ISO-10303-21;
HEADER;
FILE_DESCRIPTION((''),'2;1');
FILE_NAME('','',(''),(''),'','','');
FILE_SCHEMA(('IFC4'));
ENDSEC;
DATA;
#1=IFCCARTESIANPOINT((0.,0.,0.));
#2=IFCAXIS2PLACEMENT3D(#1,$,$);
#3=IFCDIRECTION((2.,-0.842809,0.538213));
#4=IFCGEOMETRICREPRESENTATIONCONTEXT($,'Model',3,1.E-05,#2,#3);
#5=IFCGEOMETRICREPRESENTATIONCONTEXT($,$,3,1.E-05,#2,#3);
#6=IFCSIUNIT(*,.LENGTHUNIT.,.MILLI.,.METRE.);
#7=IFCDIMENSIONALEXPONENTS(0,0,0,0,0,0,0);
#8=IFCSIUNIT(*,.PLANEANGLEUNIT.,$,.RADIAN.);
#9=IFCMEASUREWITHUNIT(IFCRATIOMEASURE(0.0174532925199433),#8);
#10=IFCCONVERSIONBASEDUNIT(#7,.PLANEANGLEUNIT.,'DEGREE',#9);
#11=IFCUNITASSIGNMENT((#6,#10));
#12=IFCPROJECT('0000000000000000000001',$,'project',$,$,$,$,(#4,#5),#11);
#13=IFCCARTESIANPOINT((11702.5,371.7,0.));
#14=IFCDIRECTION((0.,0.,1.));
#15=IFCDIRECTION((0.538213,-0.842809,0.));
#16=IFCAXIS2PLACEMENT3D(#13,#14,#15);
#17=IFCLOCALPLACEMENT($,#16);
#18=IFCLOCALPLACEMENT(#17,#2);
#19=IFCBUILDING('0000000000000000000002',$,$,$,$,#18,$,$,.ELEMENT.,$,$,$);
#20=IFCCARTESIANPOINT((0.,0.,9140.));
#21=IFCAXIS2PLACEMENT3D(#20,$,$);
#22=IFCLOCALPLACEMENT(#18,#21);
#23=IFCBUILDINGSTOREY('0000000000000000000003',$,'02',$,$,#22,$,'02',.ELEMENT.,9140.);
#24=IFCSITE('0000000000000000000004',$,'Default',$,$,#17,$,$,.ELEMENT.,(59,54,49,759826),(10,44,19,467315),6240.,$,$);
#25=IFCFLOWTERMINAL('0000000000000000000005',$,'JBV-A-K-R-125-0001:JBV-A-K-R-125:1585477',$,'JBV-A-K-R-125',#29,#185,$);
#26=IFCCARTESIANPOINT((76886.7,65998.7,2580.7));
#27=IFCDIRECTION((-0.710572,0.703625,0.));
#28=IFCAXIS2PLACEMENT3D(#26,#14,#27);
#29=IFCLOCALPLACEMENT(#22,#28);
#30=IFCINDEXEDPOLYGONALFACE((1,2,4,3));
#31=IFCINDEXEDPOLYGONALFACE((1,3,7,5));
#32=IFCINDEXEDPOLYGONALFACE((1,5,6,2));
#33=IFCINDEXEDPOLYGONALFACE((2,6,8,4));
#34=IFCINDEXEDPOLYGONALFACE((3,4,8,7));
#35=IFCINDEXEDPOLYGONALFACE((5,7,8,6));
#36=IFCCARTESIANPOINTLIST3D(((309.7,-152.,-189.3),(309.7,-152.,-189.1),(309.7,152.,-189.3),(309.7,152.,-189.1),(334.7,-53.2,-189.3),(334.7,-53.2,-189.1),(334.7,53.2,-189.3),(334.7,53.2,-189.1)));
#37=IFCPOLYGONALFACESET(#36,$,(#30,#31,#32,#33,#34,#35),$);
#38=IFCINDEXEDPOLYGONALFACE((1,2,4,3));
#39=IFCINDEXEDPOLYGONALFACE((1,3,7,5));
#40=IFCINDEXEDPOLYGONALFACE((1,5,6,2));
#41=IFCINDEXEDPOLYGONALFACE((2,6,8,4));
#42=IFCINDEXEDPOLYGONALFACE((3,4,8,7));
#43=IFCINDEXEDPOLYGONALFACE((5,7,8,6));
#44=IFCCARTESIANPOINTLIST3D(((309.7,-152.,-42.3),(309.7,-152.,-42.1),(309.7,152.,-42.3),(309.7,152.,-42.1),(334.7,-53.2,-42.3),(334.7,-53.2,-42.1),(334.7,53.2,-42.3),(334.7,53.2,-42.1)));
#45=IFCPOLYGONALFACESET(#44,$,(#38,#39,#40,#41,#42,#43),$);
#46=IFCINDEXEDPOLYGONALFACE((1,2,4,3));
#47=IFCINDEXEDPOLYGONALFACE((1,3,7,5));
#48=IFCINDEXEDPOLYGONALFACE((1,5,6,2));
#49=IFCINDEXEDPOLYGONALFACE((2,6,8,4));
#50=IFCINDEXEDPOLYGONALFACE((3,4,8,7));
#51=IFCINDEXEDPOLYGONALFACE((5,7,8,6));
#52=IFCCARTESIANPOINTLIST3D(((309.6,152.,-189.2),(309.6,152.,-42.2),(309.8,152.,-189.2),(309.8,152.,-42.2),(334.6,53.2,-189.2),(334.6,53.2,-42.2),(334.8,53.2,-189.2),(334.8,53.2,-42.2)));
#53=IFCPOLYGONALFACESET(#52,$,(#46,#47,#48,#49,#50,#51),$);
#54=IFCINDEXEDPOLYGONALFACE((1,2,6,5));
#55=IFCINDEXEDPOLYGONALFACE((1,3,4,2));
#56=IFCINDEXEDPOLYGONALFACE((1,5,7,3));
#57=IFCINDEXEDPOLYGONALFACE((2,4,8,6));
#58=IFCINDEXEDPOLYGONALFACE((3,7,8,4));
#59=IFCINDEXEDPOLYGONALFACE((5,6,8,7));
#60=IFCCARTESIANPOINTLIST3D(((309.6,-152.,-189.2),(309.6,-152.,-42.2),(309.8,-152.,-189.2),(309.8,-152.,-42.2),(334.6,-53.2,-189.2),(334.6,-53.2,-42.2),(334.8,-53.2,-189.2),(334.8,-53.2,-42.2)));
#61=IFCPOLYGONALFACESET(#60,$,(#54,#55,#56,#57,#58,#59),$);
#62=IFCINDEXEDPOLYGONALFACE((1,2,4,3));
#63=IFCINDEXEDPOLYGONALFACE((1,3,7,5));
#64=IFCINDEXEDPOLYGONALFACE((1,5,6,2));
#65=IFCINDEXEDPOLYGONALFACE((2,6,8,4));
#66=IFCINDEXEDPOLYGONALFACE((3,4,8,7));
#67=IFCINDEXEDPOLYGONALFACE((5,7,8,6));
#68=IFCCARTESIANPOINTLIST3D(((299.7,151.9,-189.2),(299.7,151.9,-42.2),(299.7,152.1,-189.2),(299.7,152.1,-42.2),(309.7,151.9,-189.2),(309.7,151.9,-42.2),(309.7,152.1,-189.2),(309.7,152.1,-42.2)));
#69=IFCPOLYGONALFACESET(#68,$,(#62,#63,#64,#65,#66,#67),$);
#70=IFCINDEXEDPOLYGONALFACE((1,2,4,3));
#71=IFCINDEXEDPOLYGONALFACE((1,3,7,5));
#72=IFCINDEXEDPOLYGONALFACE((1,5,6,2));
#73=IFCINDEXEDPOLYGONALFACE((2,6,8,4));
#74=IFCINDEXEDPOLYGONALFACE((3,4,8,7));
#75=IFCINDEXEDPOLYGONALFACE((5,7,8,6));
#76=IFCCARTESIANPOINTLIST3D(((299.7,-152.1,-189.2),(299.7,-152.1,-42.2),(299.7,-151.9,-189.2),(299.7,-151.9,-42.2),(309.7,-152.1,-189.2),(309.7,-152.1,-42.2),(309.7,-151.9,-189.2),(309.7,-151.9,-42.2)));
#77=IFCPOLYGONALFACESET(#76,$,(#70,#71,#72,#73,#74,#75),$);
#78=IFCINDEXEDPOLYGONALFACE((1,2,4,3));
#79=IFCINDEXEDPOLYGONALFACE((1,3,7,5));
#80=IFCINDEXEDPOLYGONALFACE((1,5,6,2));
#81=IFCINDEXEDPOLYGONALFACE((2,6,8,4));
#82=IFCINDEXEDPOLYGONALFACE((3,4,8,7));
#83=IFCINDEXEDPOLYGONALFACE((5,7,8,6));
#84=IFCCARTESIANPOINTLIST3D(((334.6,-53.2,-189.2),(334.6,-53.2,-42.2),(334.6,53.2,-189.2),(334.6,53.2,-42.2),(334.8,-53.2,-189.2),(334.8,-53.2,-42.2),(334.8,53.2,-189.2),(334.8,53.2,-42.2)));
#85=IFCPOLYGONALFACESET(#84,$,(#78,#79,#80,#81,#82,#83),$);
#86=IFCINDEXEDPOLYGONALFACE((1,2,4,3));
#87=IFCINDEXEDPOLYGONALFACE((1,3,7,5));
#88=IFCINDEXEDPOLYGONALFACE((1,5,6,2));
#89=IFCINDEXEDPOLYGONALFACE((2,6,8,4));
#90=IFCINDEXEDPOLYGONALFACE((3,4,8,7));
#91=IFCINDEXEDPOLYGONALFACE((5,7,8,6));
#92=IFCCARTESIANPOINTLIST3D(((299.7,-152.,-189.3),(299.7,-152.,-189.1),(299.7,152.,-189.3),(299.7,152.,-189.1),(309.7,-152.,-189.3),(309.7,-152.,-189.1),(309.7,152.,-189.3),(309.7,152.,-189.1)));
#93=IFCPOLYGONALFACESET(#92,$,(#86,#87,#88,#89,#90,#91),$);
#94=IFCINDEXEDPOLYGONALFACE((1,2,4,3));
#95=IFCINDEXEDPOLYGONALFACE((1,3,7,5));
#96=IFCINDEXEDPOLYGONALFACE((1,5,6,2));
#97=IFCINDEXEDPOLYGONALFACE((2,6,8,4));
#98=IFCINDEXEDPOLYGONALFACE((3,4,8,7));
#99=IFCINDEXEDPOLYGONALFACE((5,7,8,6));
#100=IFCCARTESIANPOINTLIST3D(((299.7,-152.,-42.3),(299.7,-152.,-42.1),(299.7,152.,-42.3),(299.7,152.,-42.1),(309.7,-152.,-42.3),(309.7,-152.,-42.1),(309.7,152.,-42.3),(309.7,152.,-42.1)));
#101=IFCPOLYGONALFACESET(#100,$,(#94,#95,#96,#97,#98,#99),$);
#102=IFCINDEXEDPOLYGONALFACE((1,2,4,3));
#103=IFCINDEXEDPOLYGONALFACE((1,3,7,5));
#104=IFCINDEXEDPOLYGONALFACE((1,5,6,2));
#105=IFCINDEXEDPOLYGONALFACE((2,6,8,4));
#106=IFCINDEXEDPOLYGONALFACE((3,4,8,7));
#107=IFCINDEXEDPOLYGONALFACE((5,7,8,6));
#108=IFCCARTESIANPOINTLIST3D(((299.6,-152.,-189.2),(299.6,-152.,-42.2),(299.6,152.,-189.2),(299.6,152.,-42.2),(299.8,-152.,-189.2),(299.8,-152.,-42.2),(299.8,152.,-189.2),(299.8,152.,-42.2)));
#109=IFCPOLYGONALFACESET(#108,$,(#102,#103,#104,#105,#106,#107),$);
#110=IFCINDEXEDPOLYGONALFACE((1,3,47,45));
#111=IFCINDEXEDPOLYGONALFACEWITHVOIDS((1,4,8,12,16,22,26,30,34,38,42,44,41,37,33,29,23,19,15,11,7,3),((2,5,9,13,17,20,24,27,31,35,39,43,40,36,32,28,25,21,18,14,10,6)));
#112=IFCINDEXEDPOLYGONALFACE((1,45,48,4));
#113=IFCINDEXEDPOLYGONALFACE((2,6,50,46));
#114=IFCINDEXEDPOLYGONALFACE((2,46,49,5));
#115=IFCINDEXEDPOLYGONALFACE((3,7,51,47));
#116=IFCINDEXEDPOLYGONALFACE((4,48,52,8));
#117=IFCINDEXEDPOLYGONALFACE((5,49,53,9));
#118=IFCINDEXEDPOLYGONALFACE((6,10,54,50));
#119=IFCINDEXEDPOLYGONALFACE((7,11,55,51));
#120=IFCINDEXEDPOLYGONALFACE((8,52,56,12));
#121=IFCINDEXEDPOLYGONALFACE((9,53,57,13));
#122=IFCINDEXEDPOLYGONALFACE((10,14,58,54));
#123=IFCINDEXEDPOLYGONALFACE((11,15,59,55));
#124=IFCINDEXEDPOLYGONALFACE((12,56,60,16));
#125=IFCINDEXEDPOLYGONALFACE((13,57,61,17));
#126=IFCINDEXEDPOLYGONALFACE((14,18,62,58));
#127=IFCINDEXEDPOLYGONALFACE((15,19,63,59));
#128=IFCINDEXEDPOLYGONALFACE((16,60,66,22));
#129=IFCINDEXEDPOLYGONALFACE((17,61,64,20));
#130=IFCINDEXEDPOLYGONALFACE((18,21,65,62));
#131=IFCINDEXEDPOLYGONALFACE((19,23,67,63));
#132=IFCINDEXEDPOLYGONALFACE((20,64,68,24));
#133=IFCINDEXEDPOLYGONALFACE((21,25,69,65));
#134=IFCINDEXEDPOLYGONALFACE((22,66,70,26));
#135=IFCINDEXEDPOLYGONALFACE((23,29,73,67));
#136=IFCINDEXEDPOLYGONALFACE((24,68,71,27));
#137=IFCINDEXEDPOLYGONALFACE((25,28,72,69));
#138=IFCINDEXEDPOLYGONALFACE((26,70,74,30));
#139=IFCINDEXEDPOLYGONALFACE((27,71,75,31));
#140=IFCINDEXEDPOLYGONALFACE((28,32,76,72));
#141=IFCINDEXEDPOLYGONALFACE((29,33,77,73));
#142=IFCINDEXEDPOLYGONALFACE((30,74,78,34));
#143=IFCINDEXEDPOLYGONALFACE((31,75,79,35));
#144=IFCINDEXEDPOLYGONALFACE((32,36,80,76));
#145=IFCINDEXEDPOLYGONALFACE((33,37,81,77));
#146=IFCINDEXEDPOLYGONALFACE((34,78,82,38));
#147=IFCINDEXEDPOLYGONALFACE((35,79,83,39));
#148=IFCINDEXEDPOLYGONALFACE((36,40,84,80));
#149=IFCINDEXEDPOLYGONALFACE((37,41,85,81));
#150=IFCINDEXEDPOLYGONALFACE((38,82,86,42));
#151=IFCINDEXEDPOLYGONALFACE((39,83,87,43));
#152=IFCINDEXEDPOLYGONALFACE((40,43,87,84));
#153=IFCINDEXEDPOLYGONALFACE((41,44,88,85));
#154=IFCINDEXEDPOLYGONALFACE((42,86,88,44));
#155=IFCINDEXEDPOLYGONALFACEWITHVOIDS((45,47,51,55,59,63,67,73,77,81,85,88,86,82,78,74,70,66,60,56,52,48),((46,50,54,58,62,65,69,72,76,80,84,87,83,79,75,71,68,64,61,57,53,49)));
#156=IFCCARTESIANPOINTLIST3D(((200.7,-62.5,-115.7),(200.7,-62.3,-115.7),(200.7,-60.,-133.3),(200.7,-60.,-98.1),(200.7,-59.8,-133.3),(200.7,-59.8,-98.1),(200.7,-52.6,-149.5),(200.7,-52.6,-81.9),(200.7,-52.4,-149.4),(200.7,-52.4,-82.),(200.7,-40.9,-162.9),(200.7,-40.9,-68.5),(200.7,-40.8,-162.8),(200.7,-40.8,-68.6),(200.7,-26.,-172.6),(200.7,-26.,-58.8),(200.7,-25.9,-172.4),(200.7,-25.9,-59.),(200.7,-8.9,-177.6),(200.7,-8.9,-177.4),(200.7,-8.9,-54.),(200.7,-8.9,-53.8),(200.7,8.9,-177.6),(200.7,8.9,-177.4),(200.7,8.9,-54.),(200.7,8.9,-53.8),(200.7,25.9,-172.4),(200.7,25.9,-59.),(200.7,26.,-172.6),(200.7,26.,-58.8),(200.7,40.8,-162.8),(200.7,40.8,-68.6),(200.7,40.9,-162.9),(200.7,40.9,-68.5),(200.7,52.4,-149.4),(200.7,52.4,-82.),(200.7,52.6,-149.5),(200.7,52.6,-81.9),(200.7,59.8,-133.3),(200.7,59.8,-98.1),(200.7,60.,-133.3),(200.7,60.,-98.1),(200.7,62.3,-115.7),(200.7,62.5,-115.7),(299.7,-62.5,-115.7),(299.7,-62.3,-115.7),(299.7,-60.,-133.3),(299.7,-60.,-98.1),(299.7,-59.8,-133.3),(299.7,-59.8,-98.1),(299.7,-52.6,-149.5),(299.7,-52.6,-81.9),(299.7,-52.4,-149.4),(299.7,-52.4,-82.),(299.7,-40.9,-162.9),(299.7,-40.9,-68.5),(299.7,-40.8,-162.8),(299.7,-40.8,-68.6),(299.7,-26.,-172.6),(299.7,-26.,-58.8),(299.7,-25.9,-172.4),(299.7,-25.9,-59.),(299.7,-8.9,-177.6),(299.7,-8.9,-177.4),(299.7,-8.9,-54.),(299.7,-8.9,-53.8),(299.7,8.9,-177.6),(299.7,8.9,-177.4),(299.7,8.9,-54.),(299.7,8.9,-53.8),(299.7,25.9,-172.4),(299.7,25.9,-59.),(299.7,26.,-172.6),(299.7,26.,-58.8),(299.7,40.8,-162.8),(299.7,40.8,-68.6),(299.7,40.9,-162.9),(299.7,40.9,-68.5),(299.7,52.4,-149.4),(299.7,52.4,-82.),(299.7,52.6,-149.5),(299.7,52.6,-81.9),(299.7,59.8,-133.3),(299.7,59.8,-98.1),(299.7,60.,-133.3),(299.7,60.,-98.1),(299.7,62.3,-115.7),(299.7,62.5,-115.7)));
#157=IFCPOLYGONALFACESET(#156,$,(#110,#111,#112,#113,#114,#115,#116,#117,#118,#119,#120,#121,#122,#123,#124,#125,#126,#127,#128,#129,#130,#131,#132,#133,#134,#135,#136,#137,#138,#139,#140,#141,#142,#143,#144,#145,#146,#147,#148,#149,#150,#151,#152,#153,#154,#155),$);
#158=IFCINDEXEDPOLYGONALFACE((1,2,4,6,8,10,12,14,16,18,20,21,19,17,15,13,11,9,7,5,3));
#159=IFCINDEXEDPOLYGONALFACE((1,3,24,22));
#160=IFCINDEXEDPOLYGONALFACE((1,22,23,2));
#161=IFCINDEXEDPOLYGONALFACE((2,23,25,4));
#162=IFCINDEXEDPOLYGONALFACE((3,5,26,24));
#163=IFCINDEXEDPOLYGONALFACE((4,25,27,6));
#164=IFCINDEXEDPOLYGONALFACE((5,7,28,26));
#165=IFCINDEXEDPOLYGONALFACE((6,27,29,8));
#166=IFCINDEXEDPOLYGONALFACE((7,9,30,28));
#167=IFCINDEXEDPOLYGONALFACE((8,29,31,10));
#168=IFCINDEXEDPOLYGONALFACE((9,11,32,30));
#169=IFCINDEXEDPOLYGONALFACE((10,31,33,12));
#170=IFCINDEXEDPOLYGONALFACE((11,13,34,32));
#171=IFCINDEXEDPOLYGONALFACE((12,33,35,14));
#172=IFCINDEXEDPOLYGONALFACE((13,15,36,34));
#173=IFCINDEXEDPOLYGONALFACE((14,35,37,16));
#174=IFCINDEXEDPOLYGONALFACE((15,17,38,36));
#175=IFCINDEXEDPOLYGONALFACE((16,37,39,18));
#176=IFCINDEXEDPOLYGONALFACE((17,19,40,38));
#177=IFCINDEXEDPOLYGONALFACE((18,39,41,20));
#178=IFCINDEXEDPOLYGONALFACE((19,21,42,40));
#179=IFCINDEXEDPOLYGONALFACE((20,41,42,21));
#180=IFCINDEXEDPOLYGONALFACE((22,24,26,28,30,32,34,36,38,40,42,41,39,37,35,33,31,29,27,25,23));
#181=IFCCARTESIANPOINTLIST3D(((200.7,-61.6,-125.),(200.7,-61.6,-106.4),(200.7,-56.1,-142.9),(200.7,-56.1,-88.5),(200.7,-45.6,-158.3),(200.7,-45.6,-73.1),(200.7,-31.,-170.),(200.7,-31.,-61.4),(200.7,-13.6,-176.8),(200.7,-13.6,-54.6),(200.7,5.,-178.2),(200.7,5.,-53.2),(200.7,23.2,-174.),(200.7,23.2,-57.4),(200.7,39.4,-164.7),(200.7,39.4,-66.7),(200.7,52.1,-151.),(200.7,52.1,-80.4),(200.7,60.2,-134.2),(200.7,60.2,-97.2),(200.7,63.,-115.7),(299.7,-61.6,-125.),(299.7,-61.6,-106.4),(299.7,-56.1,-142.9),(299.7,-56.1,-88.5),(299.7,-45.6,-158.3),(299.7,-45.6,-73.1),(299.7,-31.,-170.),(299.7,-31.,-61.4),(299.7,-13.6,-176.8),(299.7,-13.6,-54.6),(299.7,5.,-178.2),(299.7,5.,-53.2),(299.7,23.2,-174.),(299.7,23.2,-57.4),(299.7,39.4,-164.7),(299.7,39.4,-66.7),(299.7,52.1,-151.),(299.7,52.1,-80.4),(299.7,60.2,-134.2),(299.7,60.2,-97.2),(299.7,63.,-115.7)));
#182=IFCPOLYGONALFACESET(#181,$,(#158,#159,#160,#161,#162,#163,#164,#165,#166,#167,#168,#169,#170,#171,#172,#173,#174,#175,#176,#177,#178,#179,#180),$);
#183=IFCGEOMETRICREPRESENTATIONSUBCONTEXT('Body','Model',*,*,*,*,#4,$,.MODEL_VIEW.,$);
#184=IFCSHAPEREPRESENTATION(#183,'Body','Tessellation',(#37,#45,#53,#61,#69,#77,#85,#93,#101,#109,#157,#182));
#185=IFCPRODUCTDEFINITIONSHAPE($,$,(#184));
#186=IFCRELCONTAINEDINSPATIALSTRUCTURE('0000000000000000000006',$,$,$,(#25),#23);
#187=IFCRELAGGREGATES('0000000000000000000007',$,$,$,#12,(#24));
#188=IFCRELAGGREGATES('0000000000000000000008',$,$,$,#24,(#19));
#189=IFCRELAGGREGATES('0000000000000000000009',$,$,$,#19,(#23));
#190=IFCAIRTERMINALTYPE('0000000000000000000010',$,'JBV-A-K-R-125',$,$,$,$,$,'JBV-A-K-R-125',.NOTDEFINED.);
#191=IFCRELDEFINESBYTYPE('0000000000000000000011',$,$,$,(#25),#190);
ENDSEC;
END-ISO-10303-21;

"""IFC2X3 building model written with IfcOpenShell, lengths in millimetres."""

from ifc_helpers import new_model, entity, si_unit, converted_unit, direction, frame, frame_2d, origin, origin_2d_with_axis, place, context, subcontext, project, spatial, polyline, circle_curve, parameter, trimmed, segment, composite_curve, rectangle, circle, outline, extrude, source, transform, mapped, type_object, type_shapes, element, save


model = new_model("IFC2X3")

# Units and contexts
model_context = context("Model", 3, precision=1e-05, world=origin(), true_north=direction((2.0, -0.842809, 0.538213)))
context_of_model = context(None, 3, precision=1e-05, world=origin(), true_north=direction((2.0, -0.842809, 0.538213)))
body_context = subcontext(model_context, "Body", "Model", "MODEL_VIEW")
ifc_project = project(units=[si_unit("LENGTHUNIT", "METRE", prefix="MILLI"), converted_unit("PLANEANGLEUNIT", "DEGREE", entity("IfcRatioMeasure", 0.0174532925199433), si_unit("PLANEANGLEUNIT", "RADIAN"), dimensions=[0, 0, 0, 0, 0, 0, 0])], contexts=[model_context, context_of_model])

# Site, building, storey
site_placement = place(None, frame((11702.5, 371.7, 0.0), z_axis=(0.0, 0.0, 1.0), x_axis=(0.538213, -0.842809, 0.0)))
site = spatial("IfcSite", under=ifc_project, at=site_placement, Name="Default", CompositionType="ELEMENT", RefLatitude=(59, 54, 49, 759826), RefLongitude=(10, 44, 19, 467315), RefElevation=6240.0)
building_placement = place(site_placement, origin())
building = spatial("IfcBuilding", under=site, at=building_placement, CompositionType="ELEMENT")
storey_placement = place(building_placement, frame((0.0, 0.0, 9140.0)))
storey = spatial("IfcBuildingStorey", under=building, at=storey_placement, Name="02", LongName="02", CompositionType="ELEMENT", Elevation=9140.0)

# Flow terminal
air_terminal_type_1 = type_object("IfcAirTerminalType", Name="JBV-A-K-R-125", ElementType="JBV-A-K-R-125", PredefinedType="NOTDEFINED")
shared_shape_1 = source(origin(), body_context, "Body", "SweptSolid", [
    extrude(outline(polyline([(-152.0, -12.5), (152.0, -12.5), (53.2, 12.5), (-53.2, 12.5), (-152.0, -12.5)])), frame((322.2, 0.0, -189.3), z_axis=(0.0, 0.0, 1.0), x_axis=(0.0, -1.0, 0.0)), (0.0, 0.0, 1.0), 0.2),
    extrude(outline(polyline([(-152.0, -12.5), (152.0, -12.5), (53.2, 12.5), (-53.2, 12.5), (-152.0, -12.5)])), frame((322.2, 0.0, -42.3), z_axis=(0.0, 0.0, 1.0), x_axis=(0.0, -1.0, 0.0)), (0.0, 0.0, 1.0), 0.2),
    extrude(rectangle(XDim=0.2, YDim=101.9, at=frame_2d((0.0, 0.0), x_axis=(1.0, 0.0))), frame((322.2, 102.6, -189.2), z_axis=(0.0, 0.0, 1.0), x_axis=(0.969446, 0.245305, 0.0)), (0.0, 0.0, 1.0), 147.0),
    extrude(rectangle(XDim=0.2, YDim=101.9, at=frame_2d((0.0, 0.0), x_axis=(1.0, 0.0))), frame((322.2, -102.6, -189.2), z_axis=(0.0, 0.0, 1.0), x_axis=(-0.969446, 0.245305, 0.0)), (0.0, 0.0, 1.0), 147.0),
    extrude(rectangle(XDim=0.2, YDim=10.0, at=frame_2d((0.0, 0.0), x_axis=(1.0, 0.0))), frame((304.7, 152.0, -189.2), z_axis=(0.0, 0.0, 1.0), x_axis=(0.0, 1.0, 0.0)), (0.0, 0.0, 1.0), 147.0),
    extrude(rectangle(XDim=0.2, YDim=10.0, at=frame_2d((0.0, 0.0), x_axis=(1.0, 0.0))), frame((304.7, -152.0, -189.2), z_axis=(0.0, 0.0, 1.0), x_axis=(0.0, 1.0, 0.0)), (0.0, 0.0, 1.0), 147.0),
    extrude(rectangle(XDim=0.2, YDim=106.4, at=frame_2d((0.0, 0.0), x_axis=(1.0, 0.0))), frame((334.7, 0.0, -189.2)), (0.0, 0.0, 1.0), 147.0),
    extrude(rectangle(XDim=304.0, YDim=10.0, at=frame_2d((0.0, 0.0), x_axis=(1.0, 0.0))), frame((304.7, 0.0, -189.3), z_axis=(0.0, 0.0, 1.0), x_axis=(0.0, -1.0, 0.0)), (0.0, 0.0, 1.0), 0.2),
    extrude(rectangle(XDim=304.0, YDim=10.0, at=frame_2d((0.0, 0.0), x_axis=(1.0, 0.0))), frame((304.7, 0.0, -42.3), z_axis=(0.0, 0.0, 1.0), x_axis=(0.0, -1.0, 0.0)), (0.0, 0.0, 1.0), 0.2),
    extrude(rectangle(XDim=0.2, YDim=304.0, at=frame_2d((0.0, 0.0), x_axis=(1.0, 0.0))), frame((299.7, 0.0, -189.2)), (0.0, 0.0, 1.0), 147.0),
    extrude(outline(composite_curve([segment(trimmed(circle_curve(origin_2d_with_axis(), 62.5), [parameter(0.0)], [parameter(180.0)], True, "PARAMETER"), True, "CONTINUOUS"), segment(trimmed(circle_curve(origin_2d_with_axis(), 62.5), [parameter(180.0)], [parameter(360.0)], True, "PARAMETER"), True, "CONTINUOUS")], self_intersect=False), holes=[composite_curve([segment(trimmed(circle_curve(origin_2d_with_axis(), 62.3), [parameter(180.0)], [parameter(360.0)], True, "PARAMETER"), False, "CONTINUOUS"), segment(trimmed(circle_curve(origin_2d_with_axis(), 62.3), [parameter(0.0)], [parameter(180.0)], True, "PARAMETER"), False, "CONTINUOUS")], self_intersect=False)]), frame((200.7, 0.0, -115.7), z_axis=(1.0, 0.0, 0.0), x_axis=(0.0, 1.0, 0.0)), (0.0, 0.0, 1.0), 99.0),
    extrude(circle(Radius=62.6, at=frame_2d((0.0, 0.0), x_axis=(1.0, 0.0))), frame((200.7, 0.3, -115.7), z_axis=(1.0, 0.0, 0.0), x_axis=(0.0, 1.0, 0.0)), (0.0, 0.0, 1.0), 99.0),
])
type_shapes(air_terminal_type_1, [shared_shape_1])
for number, where, z_axis, x_axis, name in (
    (1, (76886.7, 65998.7, 2580.7), (0.0, 0.0, 1.0), (-0.710572, 0.703625, 0.0), "JBV-A-K-R-125-0001:JBV-A-K-R-125:1585477"),
):
    element("IfcFlowTerminal", number, at=place(storey_placement, frame(where, z_axis=z_axis, x_axis=x_axis)), inside=storey, type_object=air_terminal_type_1, Name=name, ObjectType="JBV-A-K-R-125", context=body_context, shape_type="MappedRepresentation", body=[
        mapped(shared_shape_1, transform((0.0, 0.0, 0.0), scale=1.0)),
    ])

save(model, "model.ifc")
